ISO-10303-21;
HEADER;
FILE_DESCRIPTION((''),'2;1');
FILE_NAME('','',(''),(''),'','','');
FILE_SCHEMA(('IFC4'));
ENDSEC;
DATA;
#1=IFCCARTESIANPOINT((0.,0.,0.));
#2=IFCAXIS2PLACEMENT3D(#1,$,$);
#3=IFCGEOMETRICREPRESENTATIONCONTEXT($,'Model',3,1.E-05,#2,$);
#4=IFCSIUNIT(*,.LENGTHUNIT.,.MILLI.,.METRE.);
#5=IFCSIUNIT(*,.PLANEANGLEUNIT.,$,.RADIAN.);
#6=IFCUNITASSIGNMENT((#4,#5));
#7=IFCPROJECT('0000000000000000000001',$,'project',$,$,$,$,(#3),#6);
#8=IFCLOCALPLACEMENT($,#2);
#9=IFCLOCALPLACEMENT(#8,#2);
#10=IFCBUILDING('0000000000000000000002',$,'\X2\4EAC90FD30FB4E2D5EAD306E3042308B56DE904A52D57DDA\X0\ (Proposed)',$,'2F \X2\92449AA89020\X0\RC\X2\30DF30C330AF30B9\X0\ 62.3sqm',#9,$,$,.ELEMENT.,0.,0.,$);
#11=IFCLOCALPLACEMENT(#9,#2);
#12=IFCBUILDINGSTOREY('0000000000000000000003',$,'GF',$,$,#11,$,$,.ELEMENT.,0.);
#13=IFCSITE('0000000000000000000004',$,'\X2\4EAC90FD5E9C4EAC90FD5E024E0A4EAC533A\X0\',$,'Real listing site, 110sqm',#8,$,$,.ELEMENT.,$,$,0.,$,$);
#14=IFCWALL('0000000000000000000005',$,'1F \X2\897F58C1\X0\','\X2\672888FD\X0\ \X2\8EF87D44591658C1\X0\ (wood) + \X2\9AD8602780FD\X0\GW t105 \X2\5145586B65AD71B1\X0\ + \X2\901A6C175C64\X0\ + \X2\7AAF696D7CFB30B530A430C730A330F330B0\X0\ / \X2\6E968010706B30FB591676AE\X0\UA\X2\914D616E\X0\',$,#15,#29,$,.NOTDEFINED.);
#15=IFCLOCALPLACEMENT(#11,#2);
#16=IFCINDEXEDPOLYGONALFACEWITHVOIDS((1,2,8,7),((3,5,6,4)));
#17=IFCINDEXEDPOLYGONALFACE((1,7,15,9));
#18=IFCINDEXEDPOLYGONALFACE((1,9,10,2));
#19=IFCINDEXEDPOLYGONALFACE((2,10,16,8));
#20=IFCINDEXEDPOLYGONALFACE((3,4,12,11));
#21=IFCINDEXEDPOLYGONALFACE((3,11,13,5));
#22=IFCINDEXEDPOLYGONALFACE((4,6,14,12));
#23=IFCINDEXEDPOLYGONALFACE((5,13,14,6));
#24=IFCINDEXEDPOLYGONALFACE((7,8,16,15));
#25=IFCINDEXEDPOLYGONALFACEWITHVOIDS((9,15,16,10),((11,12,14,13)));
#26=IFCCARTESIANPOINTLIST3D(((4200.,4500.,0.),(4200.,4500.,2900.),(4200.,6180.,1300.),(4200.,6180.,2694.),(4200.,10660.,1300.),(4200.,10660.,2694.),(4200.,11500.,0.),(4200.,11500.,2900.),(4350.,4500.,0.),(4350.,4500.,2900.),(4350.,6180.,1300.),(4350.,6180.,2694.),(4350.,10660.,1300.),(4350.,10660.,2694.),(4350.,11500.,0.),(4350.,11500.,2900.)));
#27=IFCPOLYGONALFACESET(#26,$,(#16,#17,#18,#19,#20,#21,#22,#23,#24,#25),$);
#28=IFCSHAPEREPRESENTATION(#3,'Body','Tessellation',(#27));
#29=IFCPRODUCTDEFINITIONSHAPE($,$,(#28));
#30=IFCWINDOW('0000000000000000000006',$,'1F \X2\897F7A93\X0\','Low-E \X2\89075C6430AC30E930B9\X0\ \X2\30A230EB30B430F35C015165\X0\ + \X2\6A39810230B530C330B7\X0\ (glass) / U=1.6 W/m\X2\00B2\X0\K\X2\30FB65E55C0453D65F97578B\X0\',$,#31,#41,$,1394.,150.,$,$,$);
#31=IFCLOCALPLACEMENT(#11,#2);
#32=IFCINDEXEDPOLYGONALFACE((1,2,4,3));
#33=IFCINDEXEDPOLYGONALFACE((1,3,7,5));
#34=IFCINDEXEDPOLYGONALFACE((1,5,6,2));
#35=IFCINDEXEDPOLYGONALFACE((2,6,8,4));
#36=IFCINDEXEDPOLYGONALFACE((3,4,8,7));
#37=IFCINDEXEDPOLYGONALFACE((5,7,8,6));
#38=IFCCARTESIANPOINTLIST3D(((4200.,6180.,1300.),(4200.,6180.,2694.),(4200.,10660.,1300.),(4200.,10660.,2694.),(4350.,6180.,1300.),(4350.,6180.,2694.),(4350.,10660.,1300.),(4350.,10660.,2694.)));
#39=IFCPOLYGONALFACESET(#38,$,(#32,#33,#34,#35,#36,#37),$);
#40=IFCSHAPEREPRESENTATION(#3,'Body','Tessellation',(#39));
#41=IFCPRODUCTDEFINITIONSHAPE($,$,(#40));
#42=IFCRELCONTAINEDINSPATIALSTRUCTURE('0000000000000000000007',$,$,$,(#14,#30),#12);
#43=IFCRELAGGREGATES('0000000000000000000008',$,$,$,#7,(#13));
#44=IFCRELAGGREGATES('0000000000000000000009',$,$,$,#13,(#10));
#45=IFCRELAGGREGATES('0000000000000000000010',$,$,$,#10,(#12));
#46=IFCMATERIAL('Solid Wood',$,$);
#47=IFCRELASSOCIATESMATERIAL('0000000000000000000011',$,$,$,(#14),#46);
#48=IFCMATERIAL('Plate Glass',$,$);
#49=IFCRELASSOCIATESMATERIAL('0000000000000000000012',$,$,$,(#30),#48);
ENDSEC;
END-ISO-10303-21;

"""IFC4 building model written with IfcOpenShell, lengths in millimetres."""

from ifc_helpers import new_model, si_unit, frame, frame_2d, origin, place, context, project, spatial, rectangle, extrude, material, element, fill, save


model = new_model("IFC4")

# Units and contexts
model_context = context("Model", 3, precision=1e-05, world=origin())
ifc_project = project(units=[si_unit("LENGTHUNIT", "METRE", prefix="MILLI"), si_unit("PLANEANGLEUNIT", "RADIAN")], contexts=[model_context])

# Site, building, storey
site_placement = place(None, origin())
site = spatial("IfcSite", under=ifc_project, at=site_placement, Name="京都府京都市上京区", ObjectType="Real listing site, 110sqm", CompositionType="ELEMENT", RefElevation=0.0)
building_placement = place(site_placement, origin())
building = spatial("IfcBuilding", under=site, at=building_placement, Name="京都・中庭のある回遊動線 (Proposed)", ObjectType="2F 鉄骨造RCミックス 62.3sqm", CompositionType="ELEMENT", ElevationOfRefHeight=0.0, ElevationOfTerrain=0.0)
storey_placement = place(building_placement, origin())
storey = spatial("IfcBuildingStorey", under=building, at=storey_placement, Name="GF", CompositionType="ELEMENT", Elevation=0.0)

# Shared definitions
ifc_material_1 = material(Name="Solid Wood")

# Shared definitions
ifc_material_2 = material(Name="Plate Glass")

# Wall, opening, window
wall_1_placement = place(storey_placement, frame((2100.0, 2250.0, 0.0)))
wall_1 = element("IfcWall", 1, at=wall_1_placement, inside=storey, material=ifc_material_1, Name="1F 西壁", Description="木製 軸組外壁 (wood) + 高性能GW t105 充填断熱 + 通気層 + 窯業系サイディング / 準耐火・外皮UA配慮", PredefinedType="NOTDEFINED", context=model_context, shape_type="SweptSolid", body=[
    extrude(rectangle(XDim=150.0, YDim=7000.0, at=frame_2d((75.0, 3500.0))), frame((2100.0, 2250.0, 0.0)), (0.0, 0.0, 1.0), 2900.0),
])
opening_1_placement = place(storey_placement, frame((2100.0, 3090.0, 650.0)))
opening_1 = element("IfcOpeningElement", 2, at=opening_1_placement, cuts=wall_1, PredefinedType="NOTDEFINED", context=model_context, shape_type="SweptSolid", body=[
    extrude(rectangle(XDim=150.0, YDim=4480.0, at=frame_2d((75.0, 2240.0))), frame((2100.0, 3090.0, 650.0)), (0.0, 0.0, 1.0), 1394.0),
])
window_1_placement = place(storey_placement, frame((2100.0, 3090.0, 650.0)))
window_1 = element("IfcWindow", 3, at=window_1_placement, inside=storey, material=ifc_material_2, Name="1F 西窓", Description="Low-E 複層ガラス アルゴン封入 + 樹脂サッシ (glass) / U=1.6 W/m²K・日射取得型", OverallHeight=1394.0, OverallWidth=150.0, context=model_context, shape_type="SweptSolid", body=[
    extrude(rectangle(XDim=150.0, YDim=4480.0, at=frame_2d((75.0, 2240.0))), frame((2100.0, 3090.0, 650.0)), (0.0, 0.0, 1.0), 1394.0),
])
fill(opening_1, window_1)

save(model, "model.ifc")
